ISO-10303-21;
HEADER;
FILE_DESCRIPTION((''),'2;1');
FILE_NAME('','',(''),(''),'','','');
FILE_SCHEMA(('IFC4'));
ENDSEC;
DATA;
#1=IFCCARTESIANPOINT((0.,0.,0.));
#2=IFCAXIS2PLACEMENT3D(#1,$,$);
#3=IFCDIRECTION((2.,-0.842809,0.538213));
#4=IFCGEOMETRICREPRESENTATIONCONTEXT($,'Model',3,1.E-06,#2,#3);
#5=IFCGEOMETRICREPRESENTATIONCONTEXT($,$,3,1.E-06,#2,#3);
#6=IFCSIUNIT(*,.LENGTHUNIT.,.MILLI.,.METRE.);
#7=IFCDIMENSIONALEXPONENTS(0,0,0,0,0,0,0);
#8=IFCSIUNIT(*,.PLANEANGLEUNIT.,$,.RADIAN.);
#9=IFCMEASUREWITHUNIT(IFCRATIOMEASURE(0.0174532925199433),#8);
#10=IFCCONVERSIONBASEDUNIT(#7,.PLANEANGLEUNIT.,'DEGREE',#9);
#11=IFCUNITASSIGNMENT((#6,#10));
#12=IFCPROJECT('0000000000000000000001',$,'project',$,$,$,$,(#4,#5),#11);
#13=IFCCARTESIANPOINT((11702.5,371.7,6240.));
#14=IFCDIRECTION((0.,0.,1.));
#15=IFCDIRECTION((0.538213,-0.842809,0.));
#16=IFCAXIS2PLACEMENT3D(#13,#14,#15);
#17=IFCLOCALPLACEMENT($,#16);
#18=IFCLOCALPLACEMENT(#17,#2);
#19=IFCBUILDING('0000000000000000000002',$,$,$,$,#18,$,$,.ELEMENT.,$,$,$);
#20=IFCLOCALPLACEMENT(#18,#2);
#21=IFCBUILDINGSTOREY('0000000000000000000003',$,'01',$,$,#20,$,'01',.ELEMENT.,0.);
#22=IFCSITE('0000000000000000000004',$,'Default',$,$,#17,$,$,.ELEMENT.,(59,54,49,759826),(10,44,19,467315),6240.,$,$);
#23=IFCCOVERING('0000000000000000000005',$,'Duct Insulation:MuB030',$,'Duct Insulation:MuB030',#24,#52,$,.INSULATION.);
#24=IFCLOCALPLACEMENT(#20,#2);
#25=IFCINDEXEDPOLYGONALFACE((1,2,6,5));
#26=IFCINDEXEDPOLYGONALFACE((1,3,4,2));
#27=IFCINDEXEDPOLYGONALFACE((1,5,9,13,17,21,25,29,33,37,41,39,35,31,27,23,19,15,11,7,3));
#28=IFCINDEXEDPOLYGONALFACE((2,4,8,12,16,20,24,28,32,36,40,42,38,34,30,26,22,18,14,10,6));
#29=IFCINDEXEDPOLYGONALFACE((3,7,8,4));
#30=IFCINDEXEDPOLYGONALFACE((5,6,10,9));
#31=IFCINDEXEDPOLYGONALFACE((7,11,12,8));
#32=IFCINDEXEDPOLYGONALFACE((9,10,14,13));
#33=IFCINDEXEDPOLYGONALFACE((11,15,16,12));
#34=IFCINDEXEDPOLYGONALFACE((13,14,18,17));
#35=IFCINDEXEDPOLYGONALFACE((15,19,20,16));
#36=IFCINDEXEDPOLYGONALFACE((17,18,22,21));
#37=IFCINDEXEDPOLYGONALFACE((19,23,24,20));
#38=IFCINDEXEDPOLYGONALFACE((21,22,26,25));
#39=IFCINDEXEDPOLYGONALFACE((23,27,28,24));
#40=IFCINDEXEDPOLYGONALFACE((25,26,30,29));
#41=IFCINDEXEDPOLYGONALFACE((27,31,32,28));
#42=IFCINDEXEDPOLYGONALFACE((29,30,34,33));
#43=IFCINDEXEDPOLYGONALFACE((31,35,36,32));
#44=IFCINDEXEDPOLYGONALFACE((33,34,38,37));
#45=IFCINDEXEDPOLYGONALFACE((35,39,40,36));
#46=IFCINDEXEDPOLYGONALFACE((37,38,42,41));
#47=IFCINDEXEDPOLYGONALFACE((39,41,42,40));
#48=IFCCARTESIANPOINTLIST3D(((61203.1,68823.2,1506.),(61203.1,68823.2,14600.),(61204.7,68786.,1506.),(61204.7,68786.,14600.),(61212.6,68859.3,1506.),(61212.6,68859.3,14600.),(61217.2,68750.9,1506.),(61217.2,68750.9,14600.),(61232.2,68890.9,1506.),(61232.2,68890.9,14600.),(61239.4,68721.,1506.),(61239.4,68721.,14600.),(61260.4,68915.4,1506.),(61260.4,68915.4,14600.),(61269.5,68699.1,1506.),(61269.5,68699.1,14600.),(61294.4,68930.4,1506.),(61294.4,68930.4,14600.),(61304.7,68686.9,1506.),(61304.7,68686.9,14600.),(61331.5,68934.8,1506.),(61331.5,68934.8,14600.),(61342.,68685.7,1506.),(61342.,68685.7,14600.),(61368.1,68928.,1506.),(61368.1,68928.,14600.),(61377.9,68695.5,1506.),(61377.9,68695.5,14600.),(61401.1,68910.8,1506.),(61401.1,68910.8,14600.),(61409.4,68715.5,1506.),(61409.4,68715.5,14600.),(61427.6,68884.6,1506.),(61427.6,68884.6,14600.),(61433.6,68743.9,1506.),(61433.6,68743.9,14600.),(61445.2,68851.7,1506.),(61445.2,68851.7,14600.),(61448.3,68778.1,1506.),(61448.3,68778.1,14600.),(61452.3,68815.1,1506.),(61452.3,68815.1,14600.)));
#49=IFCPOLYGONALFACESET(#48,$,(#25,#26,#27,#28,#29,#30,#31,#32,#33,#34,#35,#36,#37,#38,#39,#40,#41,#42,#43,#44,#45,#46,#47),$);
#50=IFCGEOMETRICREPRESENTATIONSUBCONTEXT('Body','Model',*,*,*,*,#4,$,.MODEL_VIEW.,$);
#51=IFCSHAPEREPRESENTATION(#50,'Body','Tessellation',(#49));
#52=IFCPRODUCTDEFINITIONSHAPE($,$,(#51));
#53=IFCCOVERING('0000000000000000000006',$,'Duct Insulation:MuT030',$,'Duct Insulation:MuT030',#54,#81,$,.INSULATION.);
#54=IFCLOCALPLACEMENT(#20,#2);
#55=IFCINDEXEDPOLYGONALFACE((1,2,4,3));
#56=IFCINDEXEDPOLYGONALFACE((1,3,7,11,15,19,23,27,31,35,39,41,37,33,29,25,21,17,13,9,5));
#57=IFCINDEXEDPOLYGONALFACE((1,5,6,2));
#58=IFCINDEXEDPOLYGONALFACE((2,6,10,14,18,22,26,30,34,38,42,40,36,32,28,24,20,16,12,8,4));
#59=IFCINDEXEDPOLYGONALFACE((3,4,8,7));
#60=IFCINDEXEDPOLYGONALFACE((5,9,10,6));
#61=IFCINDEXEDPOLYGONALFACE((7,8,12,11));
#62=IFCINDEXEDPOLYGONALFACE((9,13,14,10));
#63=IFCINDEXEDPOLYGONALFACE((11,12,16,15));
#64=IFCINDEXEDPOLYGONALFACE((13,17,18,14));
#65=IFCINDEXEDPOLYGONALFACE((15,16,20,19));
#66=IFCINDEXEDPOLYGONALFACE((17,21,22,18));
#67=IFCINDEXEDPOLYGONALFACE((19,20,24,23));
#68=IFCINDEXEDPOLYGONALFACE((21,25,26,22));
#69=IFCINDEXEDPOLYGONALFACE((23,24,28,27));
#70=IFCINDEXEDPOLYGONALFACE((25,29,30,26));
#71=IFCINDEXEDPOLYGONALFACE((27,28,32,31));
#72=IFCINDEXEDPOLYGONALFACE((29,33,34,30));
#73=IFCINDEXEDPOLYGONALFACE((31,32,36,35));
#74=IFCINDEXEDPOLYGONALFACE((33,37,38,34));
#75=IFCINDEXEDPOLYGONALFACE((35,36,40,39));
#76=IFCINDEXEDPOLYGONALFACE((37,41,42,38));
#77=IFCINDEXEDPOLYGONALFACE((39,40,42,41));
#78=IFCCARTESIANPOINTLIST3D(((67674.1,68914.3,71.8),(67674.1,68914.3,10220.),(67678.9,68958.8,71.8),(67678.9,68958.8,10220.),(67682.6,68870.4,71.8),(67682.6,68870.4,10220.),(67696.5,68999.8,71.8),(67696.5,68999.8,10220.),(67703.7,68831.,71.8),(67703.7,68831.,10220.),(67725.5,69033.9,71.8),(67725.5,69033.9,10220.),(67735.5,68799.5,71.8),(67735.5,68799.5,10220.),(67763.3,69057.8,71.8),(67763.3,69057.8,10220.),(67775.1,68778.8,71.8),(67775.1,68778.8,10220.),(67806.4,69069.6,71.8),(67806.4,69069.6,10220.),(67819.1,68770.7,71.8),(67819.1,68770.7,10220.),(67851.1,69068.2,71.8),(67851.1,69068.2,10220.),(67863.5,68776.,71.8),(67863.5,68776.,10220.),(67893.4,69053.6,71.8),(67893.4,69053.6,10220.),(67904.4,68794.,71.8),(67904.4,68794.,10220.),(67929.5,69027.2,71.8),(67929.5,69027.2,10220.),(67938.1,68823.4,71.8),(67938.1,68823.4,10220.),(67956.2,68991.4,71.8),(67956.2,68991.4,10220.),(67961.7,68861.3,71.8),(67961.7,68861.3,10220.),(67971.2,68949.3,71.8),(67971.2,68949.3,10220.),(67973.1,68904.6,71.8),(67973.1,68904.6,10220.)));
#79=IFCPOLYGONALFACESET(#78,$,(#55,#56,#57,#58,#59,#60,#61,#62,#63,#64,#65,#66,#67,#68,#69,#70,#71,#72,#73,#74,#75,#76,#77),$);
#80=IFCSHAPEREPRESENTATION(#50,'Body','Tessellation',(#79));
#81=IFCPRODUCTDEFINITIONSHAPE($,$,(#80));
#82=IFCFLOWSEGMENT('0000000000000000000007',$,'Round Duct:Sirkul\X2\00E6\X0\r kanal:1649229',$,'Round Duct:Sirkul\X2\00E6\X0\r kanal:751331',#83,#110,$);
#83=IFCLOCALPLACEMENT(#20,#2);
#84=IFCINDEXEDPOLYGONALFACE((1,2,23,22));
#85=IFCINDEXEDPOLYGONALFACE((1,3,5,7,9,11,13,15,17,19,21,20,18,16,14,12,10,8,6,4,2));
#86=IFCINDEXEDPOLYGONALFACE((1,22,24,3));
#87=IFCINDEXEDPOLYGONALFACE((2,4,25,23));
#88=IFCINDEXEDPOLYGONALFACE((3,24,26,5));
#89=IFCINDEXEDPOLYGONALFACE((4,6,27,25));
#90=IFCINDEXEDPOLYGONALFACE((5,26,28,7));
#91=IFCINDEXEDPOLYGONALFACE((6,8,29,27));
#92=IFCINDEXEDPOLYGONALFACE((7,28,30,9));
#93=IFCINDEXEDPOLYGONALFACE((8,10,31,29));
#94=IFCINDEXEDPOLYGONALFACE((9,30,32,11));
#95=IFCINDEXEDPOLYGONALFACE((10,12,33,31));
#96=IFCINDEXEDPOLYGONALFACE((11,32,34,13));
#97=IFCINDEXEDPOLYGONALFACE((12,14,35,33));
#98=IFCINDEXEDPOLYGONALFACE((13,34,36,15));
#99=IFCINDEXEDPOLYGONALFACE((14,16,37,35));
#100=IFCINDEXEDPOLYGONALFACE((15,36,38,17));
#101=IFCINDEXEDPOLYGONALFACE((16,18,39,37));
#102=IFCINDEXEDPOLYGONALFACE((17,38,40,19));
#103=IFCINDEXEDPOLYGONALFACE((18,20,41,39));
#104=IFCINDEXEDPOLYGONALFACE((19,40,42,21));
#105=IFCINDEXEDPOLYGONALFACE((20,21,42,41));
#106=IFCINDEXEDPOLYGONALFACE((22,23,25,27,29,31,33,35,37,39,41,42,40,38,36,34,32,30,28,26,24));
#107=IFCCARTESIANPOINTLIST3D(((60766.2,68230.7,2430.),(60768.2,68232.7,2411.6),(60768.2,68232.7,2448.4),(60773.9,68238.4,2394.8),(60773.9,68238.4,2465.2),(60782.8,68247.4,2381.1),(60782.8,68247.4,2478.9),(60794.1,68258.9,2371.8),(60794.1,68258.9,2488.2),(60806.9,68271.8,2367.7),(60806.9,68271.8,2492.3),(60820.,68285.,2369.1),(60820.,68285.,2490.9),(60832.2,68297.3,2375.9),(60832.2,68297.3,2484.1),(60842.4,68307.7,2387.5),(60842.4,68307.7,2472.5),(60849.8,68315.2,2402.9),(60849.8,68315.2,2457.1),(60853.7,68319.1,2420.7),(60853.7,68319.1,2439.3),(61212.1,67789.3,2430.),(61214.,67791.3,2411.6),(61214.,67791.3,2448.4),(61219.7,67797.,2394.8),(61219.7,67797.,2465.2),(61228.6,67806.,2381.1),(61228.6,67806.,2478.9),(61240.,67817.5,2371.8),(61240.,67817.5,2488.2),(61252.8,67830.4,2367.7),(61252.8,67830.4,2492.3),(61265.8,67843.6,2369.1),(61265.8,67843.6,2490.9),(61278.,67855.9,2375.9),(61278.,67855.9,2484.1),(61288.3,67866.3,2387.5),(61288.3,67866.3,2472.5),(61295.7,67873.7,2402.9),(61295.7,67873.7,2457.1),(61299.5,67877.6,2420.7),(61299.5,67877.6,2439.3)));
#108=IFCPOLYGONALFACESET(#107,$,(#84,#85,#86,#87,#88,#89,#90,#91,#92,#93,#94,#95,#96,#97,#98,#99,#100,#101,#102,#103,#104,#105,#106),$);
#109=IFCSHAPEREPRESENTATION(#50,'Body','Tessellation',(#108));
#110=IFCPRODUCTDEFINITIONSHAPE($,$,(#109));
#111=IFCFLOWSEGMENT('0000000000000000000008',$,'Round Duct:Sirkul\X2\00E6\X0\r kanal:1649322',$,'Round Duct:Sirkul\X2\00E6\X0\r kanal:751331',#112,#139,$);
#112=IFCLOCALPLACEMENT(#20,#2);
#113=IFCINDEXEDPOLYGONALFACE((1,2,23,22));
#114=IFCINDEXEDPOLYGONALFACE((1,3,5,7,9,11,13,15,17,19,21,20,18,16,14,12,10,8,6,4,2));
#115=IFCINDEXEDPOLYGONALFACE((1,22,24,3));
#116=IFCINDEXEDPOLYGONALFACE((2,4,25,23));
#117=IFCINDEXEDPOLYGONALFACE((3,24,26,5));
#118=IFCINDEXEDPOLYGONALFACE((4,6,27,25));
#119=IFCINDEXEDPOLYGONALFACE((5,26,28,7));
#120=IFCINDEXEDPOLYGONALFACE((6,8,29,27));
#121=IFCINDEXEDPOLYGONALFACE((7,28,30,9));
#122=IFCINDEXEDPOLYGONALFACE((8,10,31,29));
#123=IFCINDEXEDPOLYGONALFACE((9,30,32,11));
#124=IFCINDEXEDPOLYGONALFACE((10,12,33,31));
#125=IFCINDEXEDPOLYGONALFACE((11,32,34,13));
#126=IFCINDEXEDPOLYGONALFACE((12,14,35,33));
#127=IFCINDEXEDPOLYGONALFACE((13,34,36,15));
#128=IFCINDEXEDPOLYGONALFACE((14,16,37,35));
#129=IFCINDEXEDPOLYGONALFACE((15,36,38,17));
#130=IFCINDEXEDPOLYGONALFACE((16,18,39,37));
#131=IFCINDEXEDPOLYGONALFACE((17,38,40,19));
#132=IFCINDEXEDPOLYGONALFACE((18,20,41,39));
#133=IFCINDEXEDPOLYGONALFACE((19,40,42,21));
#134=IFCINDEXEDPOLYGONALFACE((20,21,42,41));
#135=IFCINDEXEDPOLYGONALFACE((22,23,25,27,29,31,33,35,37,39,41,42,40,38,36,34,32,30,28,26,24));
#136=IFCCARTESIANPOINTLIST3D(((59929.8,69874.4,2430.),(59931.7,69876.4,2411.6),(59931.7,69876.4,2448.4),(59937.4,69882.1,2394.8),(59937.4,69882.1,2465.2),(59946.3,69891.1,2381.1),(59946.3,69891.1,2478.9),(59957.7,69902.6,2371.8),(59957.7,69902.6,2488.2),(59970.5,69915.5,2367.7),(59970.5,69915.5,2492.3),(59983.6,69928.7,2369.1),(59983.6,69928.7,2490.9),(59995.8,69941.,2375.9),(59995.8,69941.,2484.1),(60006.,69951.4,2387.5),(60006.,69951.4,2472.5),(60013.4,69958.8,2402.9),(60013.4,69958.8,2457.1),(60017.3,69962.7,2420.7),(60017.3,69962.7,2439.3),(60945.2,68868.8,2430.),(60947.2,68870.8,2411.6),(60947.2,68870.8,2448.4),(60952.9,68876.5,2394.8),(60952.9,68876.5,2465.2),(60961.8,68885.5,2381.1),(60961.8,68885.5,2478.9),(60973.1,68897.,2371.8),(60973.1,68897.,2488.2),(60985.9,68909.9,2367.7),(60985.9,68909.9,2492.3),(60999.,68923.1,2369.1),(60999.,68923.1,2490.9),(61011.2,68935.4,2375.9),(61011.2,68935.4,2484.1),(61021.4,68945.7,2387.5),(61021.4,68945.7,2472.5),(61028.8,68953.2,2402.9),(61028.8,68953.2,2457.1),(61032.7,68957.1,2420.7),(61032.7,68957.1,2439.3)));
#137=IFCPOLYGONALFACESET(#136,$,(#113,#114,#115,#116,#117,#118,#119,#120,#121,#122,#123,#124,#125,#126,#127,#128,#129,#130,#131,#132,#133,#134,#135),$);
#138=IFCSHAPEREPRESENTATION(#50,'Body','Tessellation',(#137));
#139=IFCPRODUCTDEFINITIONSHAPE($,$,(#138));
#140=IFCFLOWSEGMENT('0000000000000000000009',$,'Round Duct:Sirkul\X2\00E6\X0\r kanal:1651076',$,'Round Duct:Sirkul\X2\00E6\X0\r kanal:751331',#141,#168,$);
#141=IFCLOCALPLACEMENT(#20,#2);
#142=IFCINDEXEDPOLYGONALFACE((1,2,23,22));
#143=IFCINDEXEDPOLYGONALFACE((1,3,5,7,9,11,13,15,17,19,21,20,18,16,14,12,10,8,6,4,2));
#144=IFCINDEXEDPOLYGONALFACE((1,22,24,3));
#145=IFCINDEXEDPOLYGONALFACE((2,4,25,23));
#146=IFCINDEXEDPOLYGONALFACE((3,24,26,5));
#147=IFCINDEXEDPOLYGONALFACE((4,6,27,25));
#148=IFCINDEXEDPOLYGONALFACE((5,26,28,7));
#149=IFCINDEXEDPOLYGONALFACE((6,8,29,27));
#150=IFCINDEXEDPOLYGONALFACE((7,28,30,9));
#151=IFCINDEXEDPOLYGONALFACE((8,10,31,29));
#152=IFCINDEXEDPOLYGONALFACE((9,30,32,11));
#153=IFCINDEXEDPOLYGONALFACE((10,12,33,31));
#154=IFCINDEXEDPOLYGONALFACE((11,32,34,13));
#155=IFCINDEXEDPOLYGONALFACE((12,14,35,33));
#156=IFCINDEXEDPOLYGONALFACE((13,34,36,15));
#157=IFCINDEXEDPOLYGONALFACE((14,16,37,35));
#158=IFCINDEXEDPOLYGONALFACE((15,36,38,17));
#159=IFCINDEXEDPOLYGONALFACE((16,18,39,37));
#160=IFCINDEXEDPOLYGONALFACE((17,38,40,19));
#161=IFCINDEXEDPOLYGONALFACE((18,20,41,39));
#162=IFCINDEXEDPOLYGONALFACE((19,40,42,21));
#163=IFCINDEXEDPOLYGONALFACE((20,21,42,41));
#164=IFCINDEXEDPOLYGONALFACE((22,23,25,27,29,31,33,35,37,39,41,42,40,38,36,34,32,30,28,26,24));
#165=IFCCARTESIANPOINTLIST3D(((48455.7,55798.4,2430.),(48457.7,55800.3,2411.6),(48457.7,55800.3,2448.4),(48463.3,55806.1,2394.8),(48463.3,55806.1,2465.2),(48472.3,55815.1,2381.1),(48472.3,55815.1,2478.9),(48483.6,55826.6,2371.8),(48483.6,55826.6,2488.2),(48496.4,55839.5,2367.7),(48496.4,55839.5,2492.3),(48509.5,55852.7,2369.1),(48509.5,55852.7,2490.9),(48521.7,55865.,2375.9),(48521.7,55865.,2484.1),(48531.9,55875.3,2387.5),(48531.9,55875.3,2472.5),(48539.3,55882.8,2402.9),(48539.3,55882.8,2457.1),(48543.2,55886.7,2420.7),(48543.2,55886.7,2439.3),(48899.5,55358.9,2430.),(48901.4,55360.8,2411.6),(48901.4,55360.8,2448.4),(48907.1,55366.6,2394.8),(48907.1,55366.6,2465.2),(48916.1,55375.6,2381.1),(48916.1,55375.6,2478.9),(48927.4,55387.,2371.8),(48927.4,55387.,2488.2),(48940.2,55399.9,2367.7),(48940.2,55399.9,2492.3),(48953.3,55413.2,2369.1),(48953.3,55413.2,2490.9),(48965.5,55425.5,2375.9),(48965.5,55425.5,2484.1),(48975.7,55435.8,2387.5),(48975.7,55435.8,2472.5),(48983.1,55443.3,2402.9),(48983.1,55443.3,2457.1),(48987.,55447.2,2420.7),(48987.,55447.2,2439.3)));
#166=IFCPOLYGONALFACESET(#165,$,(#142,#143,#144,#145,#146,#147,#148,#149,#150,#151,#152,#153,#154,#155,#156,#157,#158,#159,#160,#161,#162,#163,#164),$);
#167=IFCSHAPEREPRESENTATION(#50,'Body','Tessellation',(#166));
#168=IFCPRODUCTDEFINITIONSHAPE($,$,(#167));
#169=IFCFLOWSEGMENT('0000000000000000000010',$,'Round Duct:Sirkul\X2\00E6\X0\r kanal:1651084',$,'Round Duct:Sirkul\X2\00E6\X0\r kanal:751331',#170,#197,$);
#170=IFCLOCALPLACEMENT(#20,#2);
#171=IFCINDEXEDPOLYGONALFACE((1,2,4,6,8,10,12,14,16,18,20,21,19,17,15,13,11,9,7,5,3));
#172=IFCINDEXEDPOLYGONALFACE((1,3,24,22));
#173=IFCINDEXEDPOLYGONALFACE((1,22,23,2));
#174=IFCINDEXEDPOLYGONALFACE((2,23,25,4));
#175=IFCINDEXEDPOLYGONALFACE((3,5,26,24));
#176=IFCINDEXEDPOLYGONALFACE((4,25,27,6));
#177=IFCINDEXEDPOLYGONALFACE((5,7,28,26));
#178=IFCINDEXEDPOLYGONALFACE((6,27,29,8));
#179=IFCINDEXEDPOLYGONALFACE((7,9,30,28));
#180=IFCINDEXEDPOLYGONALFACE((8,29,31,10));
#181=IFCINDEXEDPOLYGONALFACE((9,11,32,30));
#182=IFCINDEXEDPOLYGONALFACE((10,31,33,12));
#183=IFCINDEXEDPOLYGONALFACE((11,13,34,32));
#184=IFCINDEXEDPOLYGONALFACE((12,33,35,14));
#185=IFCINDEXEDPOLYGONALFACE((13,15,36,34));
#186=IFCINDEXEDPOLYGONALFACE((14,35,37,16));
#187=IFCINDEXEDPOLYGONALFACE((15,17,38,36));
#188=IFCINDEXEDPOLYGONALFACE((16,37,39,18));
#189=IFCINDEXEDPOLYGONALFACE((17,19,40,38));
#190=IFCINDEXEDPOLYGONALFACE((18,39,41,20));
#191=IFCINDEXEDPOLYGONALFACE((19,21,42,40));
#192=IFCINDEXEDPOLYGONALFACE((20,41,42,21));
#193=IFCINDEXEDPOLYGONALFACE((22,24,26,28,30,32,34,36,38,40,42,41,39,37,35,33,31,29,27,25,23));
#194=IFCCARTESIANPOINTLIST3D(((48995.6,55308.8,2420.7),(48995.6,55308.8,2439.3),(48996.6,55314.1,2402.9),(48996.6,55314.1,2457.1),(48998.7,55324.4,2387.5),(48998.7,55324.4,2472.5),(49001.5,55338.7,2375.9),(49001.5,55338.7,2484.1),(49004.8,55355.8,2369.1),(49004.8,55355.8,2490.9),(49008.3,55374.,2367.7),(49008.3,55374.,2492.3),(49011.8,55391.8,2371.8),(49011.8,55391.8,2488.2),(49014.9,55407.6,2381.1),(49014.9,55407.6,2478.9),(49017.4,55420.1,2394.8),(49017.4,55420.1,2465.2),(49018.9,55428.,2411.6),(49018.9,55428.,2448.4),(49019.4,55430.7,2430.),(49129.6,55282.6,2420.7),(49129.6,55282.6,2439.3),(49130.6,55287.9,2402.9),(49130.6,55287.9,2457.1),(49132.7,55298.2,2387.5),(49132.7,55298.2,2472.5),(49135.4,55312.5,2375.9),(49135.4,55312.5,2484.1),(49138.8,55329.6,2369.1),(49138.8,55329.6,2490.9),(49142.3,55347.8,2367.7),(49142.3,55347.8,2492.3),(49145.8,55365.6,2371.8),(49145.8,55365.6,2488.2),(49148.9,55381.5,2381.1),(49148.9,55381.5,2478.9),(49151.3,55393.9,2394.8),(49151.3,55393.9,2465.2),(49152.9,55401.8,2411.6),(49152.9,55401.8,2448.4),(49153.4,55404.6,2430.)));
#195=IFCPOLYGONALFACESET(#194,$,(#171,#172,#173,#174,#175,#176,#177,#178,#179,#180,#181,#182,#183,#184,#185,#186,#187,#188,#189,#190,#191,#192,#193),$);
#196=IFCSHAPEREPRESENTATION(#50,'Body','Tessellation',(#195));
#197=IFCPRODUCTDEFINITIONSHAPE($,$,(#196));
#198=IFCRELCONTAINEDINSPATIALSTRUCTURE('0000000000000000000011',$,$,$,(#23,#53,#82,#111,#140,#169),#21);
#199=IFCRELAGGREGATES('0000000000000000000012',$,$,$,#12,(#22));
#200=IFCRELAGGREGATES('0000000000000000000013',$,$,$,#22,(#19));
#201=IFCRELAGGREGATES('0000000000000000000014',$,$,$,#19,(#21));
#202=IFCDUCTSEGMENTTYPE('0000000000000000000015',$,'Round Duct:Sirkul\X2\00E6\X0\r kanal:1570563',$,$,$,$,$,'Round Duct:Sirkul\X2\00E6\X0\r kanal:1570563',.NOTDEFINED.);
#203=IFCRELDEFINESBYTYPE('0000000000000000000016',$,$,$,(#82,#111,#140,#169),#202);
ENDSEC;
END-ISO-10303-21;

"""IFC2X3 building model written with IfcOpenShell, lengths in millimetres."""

from ifc_helpers import new_model, entity, si_unit, converted_unit, direction, frame, frame_2d, origin, origin_2d_with_axis, place, context, subcontext, project, spatial, circle, extrude, type_object, element, save


model = new_model("IFC2X3")

# Units and contexts
model_context = context("Model", 3, precision=1e-06, world=origin(), true_north=direction((2.0, -0.842809, 0.538213)))
context_of_model = context(None, 3, precision=1e-06, world=origin(), true_north=direction((2.0, -0.842809, 0.538213)))
body_context = subcontext(model_context, "Body", "Model", "MODEL_VIEW")
ifc_project = project(units=[si_unit("LENGTHUNIT", "METRE", prefix="MILLI"), converted_unit("PLANEANGLEUNIT", "DEGREE", entity("IfcRatioMeasure", 0.0174532925199433), si_unit("PLANEANGLEUNIT", "RADIAN"), dimensions=[0, 0, 0, 0, 0, 0, 0])], contexts=[model_context, context_of_model])

# Site, building, storey
site_placement = place(None, frame((11702.5, 371.7, 6240.0), z_axis=(0.0, 0.0, 1.0), x_axis=(0.538213, -0.842809, 0.0)))
site = spatial("IfcSite", under=ifc_project, at=site_placement, Name="Default", CompositionType="ELEMENT", RefLatitude=(59, 54, 49, 759826), RefLongitude=(10, 44, 19, 467315), RefElevation=6240.0)
building_placement = place(site_placement, origin())
building = spatial("IfcBuilding", under=site, at=building_placement, CompositionType="ELEMENT")
storey_placement = place(building_placement, origin())
storey = spatial("IfcBuildingStorey", under=building, at=storey_placement, Name="01", LongName="01", CompositionType="ELEMENT", Elevation=0.0)

# Coverings
covering_1_placement = place(storey_placement, origin())
element("IfcCovering", 1, at=covering_1_placement, inside=storey, Name="Duct Insulation:MuB030", ObjectType="Duct Insulation:MuB030", PredefinedType="INSULATION", context=body_context, shape_type="SweptSolid", body=[
    extrude(circle(Radius=125.0, at=origin_2d_with_axis()), frame((61327.4, 68809.9, 1506.0), z_axis=(0.0, 0.0, 1.0), x_axis=(-0.703643, -0.710554, 0.0)), (0.0, 0.0, 1.0), 13094.0),
])
covering_2_placement = place(storey_placement, origin())
element("IfcCovering", 2, at=covering_2_placement, inside=storey, Name="Duct Insulation:MuT030", ObjectType="Duct Insulation:MuT030", PredefinedType="INSULATION", context=body_context, shape_type="SweptSolid", body=[
    extrude(circle(Radius=150.0, at=frame_2d((0.0, 0.0), x_axis=(1.0, 0.0))), frame((67823.9, 68920.7, 71.8), z_axis=(0.0, 0.0, 1.0), x_axis=(0.703643, 0.710554, 0.0)), (0.0, 0.0, 1.0), 10148.2),
])

# Flow segments
duct_segment_type = type_object("IfcDuctSegmentType", Name="Round Duct:Sirkulær kanal:1570563", ElementType="Round Duct:Sirkulær kanal:1570563", PredefinedType="NOTDEFINED")
flow_segment_1_placement = place(storey_placement, origin())
element("IfcFlowSegment", 3, at=flow_segment_1_placement, inside=storey, type_object=duct_segment_type, Name="Round Duct:Sirkulær kanal:1649229", ObjectType="Round Duct:Sirkulær kanal:751331", context=body_context, shape_type="SweptSolid", body=[
    extrude(circle(Radius=62.5, at=frame_2d((0.0, 0.0), x_axis=(1.0, 0.0))), frame((60810.2, 68275.1, 2430.0), z_axis=(0.710598, -0.703598, 0.0), x_axis=(-0.703598, -0.710598, 0.0)), (0.0, 0.0, 1.0), 627.4),
])
flow_segment_2_placement = place(storey_placement, origin())
element("IfcFlowSegment", 4, at=flow_segment_2_placement, inside=storey, type_object=duct_segment_type, Name="Round Duct:Sirkulær kanal:1649322", ObjectType="Round Duct:Sirkulær kanal:751331", context=body_context, shape_type="SweptSolid", body=[
    extrude(circle(Radius=62.5, at=origin_2d_with_axis()), frame((59973.8, 69918.8, 2430.0), z_axis=(0.710538, -0.703658, 0.0), x_axis=(-0.703658, -0.710538, 0.0)), (0.0, 0.0, 1.0), 1429.1),
])
flow_segment_3_placement = place(storey_placement, origin())
element("IfcFlowSegment", 5, at=flow_segment_3_placement, inside=storey, type_object=duct_segment_type, Name="Round Duct:Sirkulær kanal:1651076", ObjectType="Round Duct:Sirkulær kanal:751331", context=body_context, shape_type="SweptSolid", body=[
    extrude(circle(Radius=62.5, at=origin_2d_with_axis()), frame((48499.7, 55842.8, 2430.0), z_axis=(0.710524, -0.703673, 0.0), x_axis=(-0.703673, -0.710524, 0.0)), (0.0, 0.0, 1.0), 624.6),
])
flow_segment_4_placement = place(storey_placement, origin())
element("IfcFlowSegment", 6, at=flow_segment_4_placement, inside=storey, type_object=duct_segment_type, Name="Round Duct:Sirkulær kanal:1651084", ObjectType="Round Duct:Sirkulær kanal:751331", context=body_context, shape_type="SweptSolid", body=[
    extrude(circle(Radius=62.5, at=origin_2d_with_axis()), frame((49141.4, 55343.2, 2430.0), z_axis=(-0.981427, 0.191834, 0.0), x_axis=(0.191834, 0.981427, 0.0)), (0.0, 0.0, 1.0), 136.5),
])

save(model, "model.ifc")
